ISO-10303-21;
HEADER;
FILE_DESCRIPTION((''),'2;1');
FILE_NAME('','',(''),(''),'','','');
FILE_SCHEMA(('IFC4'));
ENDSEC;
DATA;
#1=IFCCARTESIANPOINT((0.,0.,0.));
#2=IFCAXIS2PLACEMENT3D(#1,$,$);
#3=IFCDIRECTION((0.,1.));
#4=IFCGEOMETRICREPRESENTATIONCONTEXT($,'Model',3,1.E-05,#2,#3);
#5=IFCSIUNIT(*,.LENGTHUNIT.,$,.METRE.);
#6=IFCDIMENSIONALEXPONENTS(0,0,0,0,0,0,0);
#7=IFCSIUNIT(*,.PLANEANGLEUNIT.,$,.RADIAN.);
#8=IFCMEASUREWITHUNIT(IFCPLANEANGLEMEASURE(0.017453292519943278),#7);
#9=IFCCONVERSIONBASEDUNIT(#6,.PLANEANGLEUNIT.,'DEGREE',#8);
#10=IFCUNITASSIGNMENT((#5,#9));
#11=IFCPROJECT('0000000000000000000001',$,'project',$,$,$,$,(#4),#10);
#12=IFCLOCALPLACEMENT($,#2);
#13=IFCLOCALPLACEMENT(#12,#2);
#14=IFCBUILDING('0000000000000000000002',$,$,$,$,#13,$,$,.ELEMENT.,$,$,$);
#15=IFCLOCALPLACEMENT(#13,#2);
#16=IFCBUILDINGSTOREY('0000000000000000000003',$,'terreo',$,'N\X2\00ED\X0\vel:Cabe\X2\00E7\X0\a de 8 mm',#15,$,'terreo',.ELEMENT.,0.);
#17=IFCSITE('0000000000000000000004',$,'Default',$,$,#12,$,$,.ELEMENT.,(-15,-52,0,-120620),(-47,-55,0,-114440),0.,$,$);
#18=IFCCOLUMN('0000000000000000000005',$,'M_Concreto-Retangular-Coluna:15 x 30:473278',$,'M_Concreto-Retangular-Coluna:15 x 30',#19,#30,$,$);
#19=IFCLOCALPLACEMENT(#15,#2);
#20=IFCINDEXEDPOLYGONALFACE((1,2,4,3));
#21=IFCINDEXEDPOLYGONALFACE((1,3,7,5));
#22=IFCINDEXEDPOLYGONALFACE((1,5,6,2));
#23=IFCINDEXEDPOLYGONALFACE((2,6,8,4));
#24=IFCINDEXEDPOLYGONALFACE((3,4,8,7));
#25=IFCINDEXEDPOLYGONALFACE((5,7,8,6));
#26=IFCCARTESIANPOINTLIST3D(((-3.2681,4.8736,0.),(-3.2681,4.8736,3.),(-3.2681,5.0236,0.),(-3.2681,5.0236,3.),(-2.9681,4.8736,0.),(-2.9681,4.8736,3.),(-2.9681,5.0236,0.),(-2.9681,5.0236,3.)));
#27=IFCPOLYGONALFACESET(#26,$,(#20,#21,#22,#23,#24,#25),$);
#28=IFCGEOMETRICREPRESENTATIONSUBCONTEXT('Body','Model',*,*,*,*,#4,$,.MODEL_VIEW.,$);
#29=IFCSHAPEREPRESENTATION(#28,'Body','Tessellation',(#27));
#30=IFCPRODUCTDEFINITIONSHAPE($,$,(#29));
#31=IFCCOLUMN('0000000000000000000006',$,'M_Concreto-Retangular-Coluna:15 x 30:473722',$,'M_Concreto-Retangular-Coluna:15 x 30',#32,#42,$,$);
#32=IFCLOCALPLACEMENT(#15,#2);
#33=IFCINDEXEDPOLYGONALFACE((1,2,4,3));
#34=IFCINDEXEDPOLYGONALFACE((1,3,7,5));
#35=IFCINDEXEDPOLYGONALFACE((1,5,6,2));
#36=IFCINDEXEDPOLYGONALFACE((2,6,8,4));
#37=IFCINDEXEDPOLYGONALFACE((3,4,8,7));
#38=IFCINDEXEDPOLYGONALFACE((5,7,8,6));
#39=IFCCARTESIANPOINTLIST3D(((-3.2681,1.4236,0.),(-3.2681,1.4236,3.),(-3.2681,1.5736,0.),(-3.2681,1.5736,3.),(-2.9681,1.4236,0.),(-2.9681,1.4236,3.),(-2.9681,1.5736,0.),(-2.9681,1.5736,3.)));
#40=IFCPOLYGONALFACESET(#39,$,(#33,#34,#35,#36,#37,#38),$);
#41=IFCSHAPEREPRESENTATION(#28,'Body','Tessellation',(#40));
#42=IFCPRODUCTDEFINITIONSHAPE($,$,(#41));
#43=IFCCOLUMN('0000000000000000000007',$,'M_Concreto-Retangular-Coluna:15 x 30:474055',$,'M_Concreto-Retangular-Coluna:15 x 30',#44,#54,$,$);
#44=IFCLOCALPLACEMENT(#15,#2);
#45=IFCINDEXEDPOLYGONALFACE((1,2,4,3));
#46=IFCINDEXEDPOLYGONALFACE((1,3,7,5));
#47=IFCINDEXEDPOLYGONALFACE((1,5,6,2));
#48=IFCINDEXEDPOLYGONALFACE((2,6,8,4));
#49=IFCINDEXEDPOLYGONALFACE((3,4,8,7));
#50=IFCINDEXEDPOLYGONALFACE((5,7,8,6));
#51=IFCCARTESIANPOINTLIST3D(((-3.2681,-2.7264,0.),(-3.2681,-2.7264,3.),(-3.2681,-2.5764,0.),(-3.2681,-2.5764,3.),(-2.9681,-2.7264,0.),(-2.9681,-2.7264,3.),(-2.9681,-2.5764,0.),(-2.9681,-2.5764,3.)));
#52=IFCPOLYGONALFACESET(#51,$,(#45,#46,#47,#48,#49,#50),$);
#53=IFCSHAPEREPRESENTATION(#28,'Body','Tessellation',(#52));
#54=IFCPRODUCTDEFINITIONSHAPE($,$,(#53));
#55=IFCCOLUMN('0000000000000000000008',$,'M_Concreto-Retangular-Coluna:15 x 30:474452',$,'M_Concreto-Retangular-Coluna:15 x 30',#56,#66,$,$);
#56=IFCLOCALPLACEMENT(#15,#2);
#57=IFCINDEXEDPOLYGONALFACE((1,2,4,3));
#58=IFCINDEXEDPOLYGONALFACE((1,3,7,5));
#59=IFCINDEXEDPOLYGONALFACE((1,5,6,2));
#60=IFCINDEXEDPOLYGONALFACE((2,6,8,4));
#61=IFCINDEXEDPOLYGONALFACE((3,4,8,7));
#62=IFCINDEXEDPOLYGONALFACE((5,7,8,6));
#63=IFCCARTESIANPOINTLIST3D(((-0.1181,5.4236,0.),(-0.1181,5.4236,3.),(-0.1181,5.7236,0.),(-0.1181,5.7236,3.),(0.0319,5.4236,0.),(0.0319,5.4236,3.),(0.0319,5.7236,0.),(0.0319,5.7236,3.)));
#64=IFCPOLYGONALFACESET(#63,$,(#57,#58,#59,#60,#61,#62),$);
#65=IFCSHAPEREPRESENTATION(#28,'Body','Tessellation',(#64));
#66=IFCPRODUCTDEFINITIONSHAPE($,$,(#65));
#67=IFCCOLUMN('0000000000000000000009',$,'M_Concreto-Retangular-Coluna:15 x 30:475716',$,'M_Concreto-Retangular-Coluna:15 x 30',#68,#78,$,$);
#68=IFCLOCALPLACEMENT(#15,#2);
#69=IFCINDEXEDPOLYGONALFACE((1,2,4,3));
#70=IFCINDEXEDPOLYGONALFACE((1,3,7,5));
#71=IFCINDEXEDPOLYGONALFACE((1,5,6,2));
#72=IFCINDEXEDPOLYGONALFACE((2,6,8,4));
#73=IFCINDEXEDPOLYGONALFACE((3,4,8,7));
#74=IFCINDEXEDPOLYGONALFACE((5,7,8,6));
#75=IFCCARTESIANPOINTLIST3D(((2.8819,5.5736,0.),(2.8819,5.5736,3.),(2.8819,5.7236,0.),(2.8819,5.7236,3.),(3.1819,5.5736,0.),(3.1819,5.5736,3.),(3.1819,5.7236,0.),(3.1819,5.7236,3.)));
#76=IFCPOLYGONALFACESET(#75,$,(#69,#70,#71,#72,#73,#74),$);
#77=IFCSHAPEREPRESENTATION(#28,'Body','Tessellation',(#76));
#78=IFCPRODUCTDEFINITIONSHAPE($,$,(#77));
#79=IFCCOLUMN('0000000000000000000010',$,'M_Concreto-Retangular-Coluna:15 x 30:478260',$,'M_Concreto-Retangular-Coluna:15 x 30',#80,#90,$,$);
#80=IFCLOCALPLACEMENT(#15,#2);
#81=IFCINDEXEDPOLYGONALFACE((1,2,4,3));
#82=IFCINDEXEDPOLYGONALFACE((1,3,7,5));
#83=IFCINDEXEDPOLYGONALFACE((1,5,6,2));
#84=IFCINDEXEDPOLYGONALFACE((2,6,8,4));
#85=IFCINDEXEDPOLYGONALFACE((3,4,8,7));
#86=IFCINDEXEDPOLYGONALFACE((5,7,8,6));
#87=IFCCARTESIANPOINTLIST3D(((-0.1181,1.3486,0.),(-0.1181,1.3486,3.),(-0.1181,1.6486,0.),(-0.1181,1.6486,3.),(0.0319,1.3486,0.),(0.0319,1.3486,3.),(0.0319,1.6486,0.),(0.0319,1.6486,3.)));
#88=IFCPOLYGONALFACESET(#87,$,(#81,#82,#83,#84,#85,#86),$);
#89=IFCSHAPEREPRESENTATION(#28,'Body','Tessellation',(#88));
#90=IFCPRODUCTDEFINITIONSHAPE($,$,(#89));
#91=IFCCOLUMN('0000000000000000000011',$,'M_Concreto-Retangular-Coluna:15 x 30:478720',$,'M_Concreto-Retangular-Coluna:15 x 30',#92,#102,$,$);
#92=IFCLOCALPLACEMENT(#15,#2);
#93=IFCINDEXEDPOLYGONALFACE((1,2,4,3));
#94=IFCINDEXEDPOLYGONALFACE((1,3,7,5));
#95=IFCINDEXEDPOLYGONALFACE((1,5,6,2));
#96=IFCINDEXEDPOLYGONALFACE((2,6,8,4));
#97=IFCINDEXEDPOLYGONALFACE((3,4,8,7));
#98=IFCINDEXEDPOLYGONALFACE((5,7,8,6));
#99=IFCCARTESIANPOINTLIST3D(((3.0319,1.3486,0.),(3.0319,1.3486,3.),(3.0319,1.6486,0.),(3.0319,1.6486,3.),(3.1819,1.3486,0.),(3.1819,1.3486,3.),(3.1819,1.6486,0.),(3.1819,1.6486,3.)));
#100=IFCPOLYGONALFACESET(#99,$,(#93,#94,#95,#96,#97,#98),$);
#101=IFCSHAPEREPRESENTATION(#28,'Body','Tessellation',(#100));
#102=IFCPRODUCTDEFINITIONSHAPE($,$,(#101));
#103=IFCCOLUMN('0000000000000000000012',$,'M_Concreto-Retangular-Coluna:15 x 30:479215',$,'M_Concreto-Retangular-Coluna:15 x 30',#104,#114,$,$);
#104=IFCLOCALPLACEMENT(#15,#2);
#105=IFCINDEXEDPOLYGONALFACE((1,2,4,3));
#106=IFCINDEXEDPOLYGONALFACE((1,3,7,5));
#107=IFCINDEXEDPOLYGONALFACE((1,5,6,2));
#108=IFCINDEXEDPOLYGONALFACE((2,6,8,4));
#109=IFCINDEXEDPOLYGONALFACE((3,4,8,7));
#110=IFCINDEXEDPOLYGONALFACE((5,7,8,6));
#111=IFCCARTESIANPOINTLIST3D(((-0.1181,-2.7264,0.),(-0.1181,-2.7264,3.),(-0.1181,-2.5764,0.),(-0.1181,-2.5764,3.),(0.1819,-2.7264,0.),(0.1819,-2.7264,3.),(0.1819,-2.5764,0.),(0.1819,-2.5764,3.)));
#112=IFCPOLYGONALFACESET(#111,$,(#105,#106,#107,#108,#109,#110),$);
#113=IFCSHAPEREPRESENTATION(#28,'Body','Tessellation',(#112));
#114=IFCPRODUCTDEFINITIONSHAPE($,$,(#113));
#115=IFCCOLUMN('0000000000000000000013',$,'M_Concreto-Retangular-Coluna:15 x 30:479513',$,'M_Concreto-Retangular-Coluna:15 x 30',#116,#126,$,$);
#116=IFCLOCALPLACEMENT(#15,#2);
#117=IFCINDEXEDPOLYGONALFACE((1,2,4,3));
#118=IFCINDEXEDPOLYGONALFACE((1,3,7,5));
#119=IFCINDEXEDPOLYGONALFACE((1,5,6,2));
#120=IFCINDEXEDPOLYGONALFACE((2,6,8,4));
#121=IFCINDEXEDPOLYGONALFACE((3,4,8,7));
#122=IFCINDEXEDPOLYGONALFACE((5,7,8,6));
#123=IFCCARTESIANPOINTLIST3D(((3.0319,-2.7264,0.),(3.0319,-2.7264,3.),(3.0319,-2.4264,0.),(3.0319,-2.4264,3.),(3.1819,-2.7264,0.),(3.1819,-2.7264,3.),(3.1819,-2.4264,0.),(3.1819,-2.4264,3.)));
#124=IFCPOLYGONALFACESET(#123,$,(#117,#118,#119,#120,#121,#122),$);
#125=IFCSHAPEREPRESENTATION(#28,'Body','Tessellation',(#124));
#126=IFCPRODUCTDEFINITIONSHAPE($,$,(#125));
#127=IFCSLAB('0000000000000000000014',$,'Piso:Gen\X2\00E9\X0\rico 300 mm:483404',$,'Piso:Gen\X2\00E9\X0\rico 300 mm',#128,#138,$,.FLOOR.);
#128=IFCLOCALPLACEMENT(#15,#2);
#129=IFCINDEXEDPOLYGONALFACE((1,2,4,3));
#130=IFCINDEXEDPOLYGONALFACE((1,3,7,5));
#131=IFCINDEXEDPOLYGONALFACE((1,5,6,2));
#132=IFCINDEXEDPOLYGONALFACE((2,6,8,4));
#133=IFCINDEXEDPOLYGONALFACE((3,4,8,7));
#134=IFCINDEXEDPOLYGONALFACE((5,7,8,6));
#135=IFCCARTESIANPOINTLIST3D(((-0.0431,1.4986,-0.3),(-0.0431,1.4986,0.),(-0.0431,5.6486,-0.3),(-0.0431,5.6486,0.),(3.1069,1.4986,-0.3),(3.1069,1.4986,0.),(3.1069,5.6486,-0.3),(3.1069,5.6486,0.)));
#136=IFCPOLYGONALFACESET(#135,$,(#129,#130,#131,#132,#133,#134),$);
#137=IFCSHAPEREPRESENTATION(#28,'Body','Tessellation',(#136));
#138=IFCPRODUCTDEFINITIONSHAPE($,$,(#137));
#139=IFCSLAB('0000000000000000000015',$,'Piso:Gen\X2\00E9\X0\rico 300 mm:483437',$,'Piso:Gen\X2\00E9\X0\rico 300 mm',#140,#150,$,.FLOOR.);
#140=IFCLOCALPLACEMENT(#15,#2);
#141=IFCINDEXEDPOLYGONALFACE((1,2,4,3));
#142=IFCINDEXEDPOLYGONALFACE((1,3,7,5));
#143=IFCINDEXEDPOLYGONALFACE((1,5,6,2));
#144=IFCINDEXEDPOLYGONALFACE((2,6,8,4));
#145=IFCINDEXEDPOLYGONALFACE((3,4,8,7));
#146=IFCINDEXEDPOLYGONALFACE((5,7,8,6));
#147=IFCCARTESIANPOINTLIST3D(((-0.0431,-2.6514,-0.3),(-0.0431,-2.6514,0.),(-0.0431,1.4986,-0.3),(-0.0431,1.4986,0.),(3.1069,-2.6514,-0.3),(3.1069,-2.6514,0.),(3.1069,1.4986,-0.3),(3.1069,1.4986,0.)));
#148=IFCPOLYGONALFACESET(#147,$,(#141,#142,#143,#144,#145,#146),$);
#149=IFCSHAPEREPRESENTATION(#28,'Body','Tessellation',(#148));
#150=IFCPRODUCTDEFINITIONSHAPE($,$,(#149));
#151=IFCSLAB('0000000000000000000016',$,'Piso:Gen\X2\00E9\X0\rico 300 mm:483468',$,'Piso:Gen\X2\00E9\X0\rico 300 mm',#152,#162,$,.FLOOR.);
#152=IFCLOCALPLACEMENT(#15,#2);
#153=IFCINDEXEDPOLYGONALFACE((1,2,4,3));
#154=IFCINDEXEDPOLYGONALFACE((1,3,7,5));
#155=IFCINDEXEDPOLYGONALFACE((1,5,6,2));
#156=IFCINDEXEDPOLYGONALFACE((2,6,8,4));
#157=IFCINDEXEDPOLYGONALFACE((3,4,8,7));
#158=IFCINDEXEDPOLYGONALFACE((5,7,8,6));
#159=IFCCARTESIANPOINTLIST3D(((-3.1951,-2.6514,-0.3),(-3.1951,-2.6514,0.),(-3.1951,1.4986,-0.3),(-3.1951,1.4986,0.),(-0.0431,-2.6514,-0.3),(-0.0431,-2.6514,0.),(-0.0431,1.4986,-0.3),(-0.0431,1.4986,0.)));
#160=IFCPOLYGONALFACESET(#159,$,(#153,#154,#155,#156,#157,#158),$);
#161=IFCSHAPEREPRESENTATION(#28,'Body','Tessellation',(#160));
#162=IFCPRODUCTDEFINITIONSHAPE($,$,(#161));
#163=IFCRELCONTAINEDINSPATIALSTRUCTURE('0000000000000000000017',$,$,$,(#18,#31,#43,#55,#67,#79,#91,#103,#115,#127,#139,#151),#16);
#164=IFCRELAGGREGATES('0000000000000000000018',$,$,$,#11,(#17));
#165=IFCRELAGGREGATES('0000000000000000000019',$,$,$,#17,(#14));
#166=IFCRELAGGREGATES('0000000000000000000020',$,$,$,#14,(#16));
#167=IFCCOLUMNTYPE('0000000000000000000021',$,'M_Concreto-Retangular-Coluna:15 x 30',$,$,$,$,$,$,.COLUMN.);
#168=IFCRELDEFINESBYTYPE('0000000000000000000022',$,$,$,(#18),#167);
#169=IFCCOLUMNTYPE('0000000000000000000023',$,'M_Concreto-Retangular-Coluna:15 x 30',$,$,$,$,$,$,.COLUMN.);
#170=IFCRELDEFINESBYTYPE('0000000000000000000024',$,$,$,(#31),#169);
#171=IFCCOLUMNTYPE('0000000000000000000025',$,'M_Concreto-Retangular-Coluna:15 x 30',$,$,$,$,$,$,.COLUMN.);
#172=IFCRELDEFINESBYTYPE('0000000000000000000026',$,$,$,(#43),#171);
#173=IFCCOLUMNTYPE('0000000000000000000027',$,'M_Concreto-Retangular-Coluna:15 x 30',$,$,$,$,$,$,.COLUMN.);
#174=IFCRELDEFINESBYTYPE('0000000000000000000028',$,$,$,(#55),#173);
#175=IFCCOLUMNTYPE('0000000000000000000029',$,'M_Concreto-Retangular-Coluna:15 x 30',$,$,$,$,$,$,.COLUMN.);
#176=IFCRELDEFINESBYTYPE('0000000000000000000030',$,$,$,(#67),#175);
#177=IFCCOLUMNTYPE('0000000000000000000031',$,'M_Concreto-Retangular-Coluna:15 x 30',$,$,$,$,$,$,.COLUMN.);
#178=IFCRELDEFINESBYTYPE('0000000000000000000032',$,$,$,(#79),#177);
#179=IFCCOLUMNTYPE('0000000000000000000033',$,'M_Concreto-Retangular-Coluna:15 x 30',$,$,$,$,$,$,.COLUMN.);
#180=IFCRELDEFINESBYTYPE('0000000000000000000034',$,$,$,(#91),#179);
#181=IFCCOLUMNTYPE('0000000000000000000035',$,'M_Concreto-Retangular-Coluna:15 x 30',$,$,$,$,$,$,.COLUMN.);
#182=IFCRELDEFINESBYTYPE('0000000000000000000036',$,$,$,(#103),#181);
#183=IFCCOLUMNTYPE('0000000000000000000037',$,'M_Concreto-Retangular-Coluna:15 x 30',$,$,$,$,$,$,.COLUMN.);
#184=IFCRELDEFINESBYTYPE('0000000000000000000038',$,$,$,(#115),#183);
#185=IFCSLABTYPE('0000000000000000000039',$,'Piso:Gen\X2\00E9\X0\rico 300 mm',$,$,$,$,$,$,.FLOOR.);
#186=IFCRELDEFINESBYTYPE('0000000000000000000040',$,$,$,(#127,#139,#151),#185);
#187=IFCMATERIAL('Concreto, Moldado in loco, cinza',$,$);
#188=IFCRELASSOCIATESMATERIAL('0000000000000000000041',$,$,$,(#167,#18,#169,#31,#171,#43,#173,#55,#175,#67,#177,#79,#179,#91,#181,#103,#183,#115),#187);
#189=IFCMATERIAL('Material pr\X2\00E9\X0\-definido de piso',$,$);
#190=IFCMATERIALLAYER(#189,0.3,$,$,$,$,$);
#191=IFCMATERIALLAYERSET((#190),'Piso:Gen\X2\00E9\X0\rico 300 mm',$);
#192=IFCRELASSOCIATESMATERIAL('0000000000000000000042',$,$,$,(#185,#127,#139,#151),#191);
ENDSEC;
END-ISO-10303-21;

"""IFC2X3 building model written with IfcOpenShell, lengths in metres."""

from ifc_helpers import new_model, entity, si_unit, converted_unit, direction, frame, frame_2d, origin, origin_2d_with_axis, place, context, subcontext, project, spatial, rectangle, extrude, source, transform, mapped, material, layer, layer_set, layer_usage, type_object, type_shapes, element, save


model = new_model("IFC2X3")

# Units and contexts
model_context = context("Model", 3, precision=1e-05, world=origin(), true_north=direction((0.0, 1.0)))
body_context = subcontext(model_context, "Body", "Model", "MODEL_VIEW")
ifc_project = project(units=[si_unit("LENGTHUNIT", "METRE"), converted_unit("PLANEANGLEUNIT", "DEGREE", entity("IfcPlaneAngleMeasure", 0.017453292519943278), si_unit("PLANEANGLEUNIT", "RADIAN"), dimensions=[0, 0, 0, 0, 0, 0, 0])], contexts=[model_context])

# Site, building, storey
site_placement = place(None, origin())
site = spatial("IfcSite", under=ifc_project, at=site_placement, Name="Default", CompositionType="ELEMENT", RefLatitude=(-15, -52, 0, -120620), RefLongitude=(-47, -55, 0, -114440), RefElevation=0.0)
building_placement = place(site_placement, origin())
building = spatial("IfcBuilding", under=site, at=building_placement, CompositionType="ELEMENT")
storey_placement = place(building_placement, origin())
storey = spatial("IfcBuildingStorey", under=building, at=storey_placement, Name="terreo", ObjectType="Nível:Cabeça de 8 mm", LongName="terreo", CompositionType="ELEMENT", Elevation=0.0)

# Columns
ifc_material_1 = material(Name="Concreto, Moldado in loco, cinza")
column_type_1 = type_object("IfcColumnType", Name="M_Concreto-Retangular-Coluna:15 x 30", PredefinedType="COLUMN", material=ifc_material_1)
shared_shape_1 = source(origin(), body_context, "Body", "SweptSolid", [
    extrude(rectangle(XDim=0.15, YDim=0.3, at=frame_2d((0.0, 0.0), x_axis=(1.0, 0.0))), frame((-3.1181, 4.9486, 0.0), z_axis=(0.0, 0.0, 1.0), x_axis=(0.0, -1.0, 0.0)), (0.0, 0.0, 1.0), 3.0),
])
type_shapes(column_type_1, [shared_shape_1])
column_1_placement = place(storey_placement, origin())
element("IfcColumn", 1, at=column_1_placement, inside=storey, type_object=column_type_1, material=ifc_material_1, Name="M_Concreto-Retangular-Coluna:15 x 30:473278", ObjectType="M_Concreto-Retangular-Coluna:15 x 30", context=body_context, shape_type="MappedRepresentation", body=[
    mapped(shared_shape_1, transform((0.0, 0.0, 0.0), scale=1.0)),
])
column_type_2 = type_object("IfcColumnType", Name="M_Concreto-Retangular-Coluna:15 x 30", PredefinedType="COLUMN", material=ifc_material_1)
shared_shape_2 = source(origin(), body_context, "Body", "SweptSolid", [
    extrude(rectangle(XDim=0.15, YDim=0.3, at=origin_2d_with_axis()), frame((-3.1181, 1.4986, 0.0), z_axis=(0.0, 0.0, 1.0), x_axis=(0.0, -1.0, 0.0)), (0.0, 0.0, 1.0), 3.0),
])
type_shapes(column_type_2, [shared_shape_2])
column_2_placement = place(storey_placement, origin())
element("IfcColumn", 2, at=column_2_placement, inside=storey, type_object=column_type_2, material=ifc_material_1, Name="M_Concreto-Retangular-Coluna:15 x 30:473722", ObjectType="M_Concreto-Retangular-Coluna:15 x 30", context=body_context, shape_type="MappedRepresentation", body=[
    mapped(shared_shape_2, transform((0.0, 0.0, 0.0), scale=1.0)),
])
column_type_3 = type_object("IfcColumnType", Name="M_Concreto-Retangular-Coluna:15 x 30", PredefinedType="COLUMN", material=ifc_material_1)
shared_shape_3 = source(origin(), body_context, "Body", "SweptSolid", [
    extrude(rectangle(XDim=0.15, YDim=0.3, at=frame_2d((0.0, 0.0), x_axis=(1.0, 0.0))), frame((-3.1181, -2.6514, 0.0), z_axis=(0.0, 0.0, 1.0), x_axis=(0.0, -1.0, 0.0)), (0.0, 0.0, 1.0), 3.0),
])
type_shapes(column_type_3, [shared_shape_3])
column_3_placement = place(storey_placement, origin())
element("IfcColumn", 3, at=column_3_placement, inside=storey, type_object=column_type_3, material=ifc_material_1, Name="M_Concreto-Retangular-Coluna:15 x 30:474055", ObjectType="M_Concreto-Retangular-Coluna:15 x 30", context=body_context, shape_type="MappedRepresentation", body=[
    mapped(shared_shape_3, transform((0.0, 0.0, 0.0), scale=1.0)),
])
column_type_4 = type_object("IfcColumnType", Name="M_Concreto-Retangular-Coluna:15 x 30", PredefinedType="COLUMN", material=ifc_material_1)
shared_shape_4 = source(origin(), body_context, "Body", "SweptSolid", [
    extrude(rectangle(XDim=0.15, YDim=0.3, at=frame_2d((0.0, 0.0), x_axis=(1.0, 0.0))), frame((-0.0431, 5.5736, 0.0), z_axis=(0.0, 0.0, 1.0), x_axis=(-1.0, 0.0, 0.0)), (0.0, 0.0, 1.0), 3.0),
])
type_shapes(column_type_4, [shared_shape_4])
column_4_placement = place(storey_placement, origin())
element("IfcColumn", 4, at=column_4_placement, inside=storey, type_object=column_type_4, material=ifc_material_1, Name="M_Concreto-Retangular-Coluna:15 x 30:474452", ObjectType="M_Concreto-Retangular-Coluna:15 x 30", context=body_context, shape_type="MappedRepresentation", body=[
    mapped(shared_shape_4, transform((0.0, 0.0, 0.0), scale=1.0)),
])
column_type_5 = type_object("IfcColumnType", Name="M_Concreto-Retangular-Coluna:15 x 30", PredefinedType="COLUMN", material=ifc_material_1)
shared_shape_5 = source(origin(), body_context, "Body", "SweptSolid", [
    extrude(rectangle(XDim=0.15, YDim=0.3, at=frame_2d((0.0, 0.0), x_axis=(1.0, 0.0))), frame((3.0319, 5.6486, 0.0), z_axis=(0.0, 0.0, 1.0), x_axis=(0.0, -1.0, 0.0)), (0.0, 0.0, 1.0), 3.0),
])
type_shapes(column_type_5, [shared_shape_5])
column_5_placement = place(storey_placement, origin())
element("IfcColumn", 5, at=column_5_placement, inside=storey, type_object=column_type_5, material=ifc_material_1, Name="M_Concreto-Retangular-Coluna:15 x 30:475716", ObjectType="M_Concreto-Retangular-Coluna:15 x 30", context=body_context, shape_type="MappedRepresentation", body=[
    mapped(shared_shape_5, transform((0.0, 0.0, 0.0), scale=1.0)),
])
column_type_6 = type_object("IfcColumnType", Name="M_Concreto-Retangular-Coluna:15 x 30", PredefinedType="COLUMN", material=ifc_material_1)
shared_shape_6 = source(origin(), body_context, "Body", "SweptSolid", [
    extrude(rectangle(XDim=0.15, YDim=0.3, at=origin_2d_with_axis()), frame((-0.0431, 1.4986, 0.0), z_axis=(0.0, 0.0, 1.0), x_axis=(-1.0, 0.0, 0.0)), (0.0, 0.0, 1.0), 3.0),
])
type_shapes(column_type_6, [shared_shape_6])
column_6_placement = place(storey_placement, origin())
element("IfcColumn", 6, at=column_6_placement, inside=storey, type_object=column_type_6, material=ifc_material_1, Name="M_Concreto-Retangular-Coluna:15 x 30:478260", ObjectType="M_Concreto-Retangular-Coluna:15 x 30", context=body_context, shape_type="MappedRepresentation", body=[
    mapped(shared_shape_6, transform((0.0, 0.0, 0.0), scale=1.0)),
])
column_type_7 = type_object("IfcColumnType", Name="M_Concreto-Retangular-Coluna:15 x 30", PredefinedType="COLUMN", material=ifc_material_1)
shared_shape_7 = source(origin(), body_context, "Body", "SweptSolid", [
    extrude(rectangle(XDim=0.15, YDim=0.3, at=frame_2d((0.0, 0.0), x_axis=(1.0, 0.0))), frame((3.1069, 1.4986, 0.0), z_axis=(0.0, 0.0, 1.0), x_axis=(-1.0, 0.0, 0.0)), (0.0, 0.0, 1.0), 3.0),
])
type_shapes(column_type_7, [shared_shape_7])
column_7_placement = place(storey_placement, origin())
element("IfcColumn", 7, at=column_7_placement, inside=storey, type_object=column_type_7, material=ifc_material_1, Name="M_Concreto-Retangular-Coluna:15 x 30:478720", ObjectType="M_Concreto-Retangular-Coluna:15 x 30", context=body_context, shape_type="MappedRepresentation", body=[
    mapped(shared_shape_7, transform((0.0, 0.0, 0.0), scale=1.0)),
])
column_type_8 = type_object("IfcColumnType", Name="M_Concreto-Retangular-Coluna:15 x 30", PredefinedType="COLUMN", material=ifc_material_1)
shared_shape_8 = source(origin(), body_context, "Body", "SweptSolid", [
    extrude(rectangle(XDim=0.15, YDim=0.3, at=frame_2d((0.0, 0.0), x_axis=(1.0, 0.0))), frame((0.0319, -2.6514, 0.0), z_axis=(0.0, 0.0, 1.0), x_axis=(0.0, -1.0, 0.0)), (0.0, 0.0, 1.0), 3.0),
])
type_shapes(column_type_8, [shared_shape_8])
column_8_placement = place(storey_placement, origin())
element("IfcColumn", 8, at=column_8_placement, inside=storey, type_object=column_type_8, material=ifc_material_1, Name="M_Concreto-Retangular-Coluna:15 x 30:479215", ObjectType="M_Concreto-Retangular-Coluna:15 x 30", context=body_context, shape_type="MappedRepresentation", body=[
    mapped(shared_shape_8, transform((0.0, 0.0, 0.0), scale=1.0)),
])
column_type_9 = type_object("IfcColumnType", Name="M_Concreto-Retangular-Coluna:15 x 30", PredefinedType="COLUMN", material=ifc_material_1)
shared_shape_9 = source(origin(), body_context, "Body", "SweptSolid", [
    extrude(rectangle(XDim=0.15, YDim=0.3, at=frame_2d((0.0, 0.0), x_axis=(1.0, 0.0))), frame((3.1069, -2.5764, 0.0), z_axis=(0.0, 0.0, 1.0), x_axis=(-1.0, 0.0, 0.0)), (0.0, 0.0, 1.0), 3.0),
])
type_shapes(column_type_9, [shared_shape_9])
column_9_placement = place(storey_placement, origin())
element("IfcColumn", 9, at=column_9_placement, inside=storey, type_object=column_type_9, material=ifc_material_1, Name="M_Concreto-Retangular-Coluna:15 x 30:479513", ObjectType="M_Concreto-Retangular-Coluna:15 x 30", context=body_context, shape_type="MappedRepresentation", body=[
    mapped(shared_shape_9, transform((0.0, 0.0, 0.0), scale=1.0)),
])

# Slabs
ifc_material_2 = material(Name="Material pré-definido de piso")
ifc_layer = layer(ifc_material_2, 0.3)
ifc_layer_set = layer_set([ifc_layer], Name="Piso:Genérico 300 mm")
ifc_layer_usage_1 = layer_usage(ifc_layer_set, "AXIS3", "POSITIVE", 0.0)
slab_type = type_object("IfcSlabType", Name="Piso:Genérico 300 mm", PredefinedType="FLOOR", material=ifc_layer_set)
slab_1_placement = place(storey_placement, origin())
element("IfcSlab", 10, at=slab_1_placement, inside=storey, type_object=slab_type, material=ifc_layer_usage_1, Name="Piso:Genérico 300 mm:483404", ObjectType="Piso:Genérico 300 mm", PredefinedType="FLOOR", context=body_context, shape_type="SweptSolid", body=[
    extrude(rectangle(XDim=4.15, YDim=3.15, at=origin_2d_with_axis()), frame((1.5319, 3.5736, 0.0), z_axis=(0.0, 0.0, -1.0), x_axis=(0.0, 1.0, 0.0)), (0.0, 0.0, 1.0), 0.3),
])
ifc_layer_usage_2 = layer_usage(ifc_layer_set, "AXIS3", "POSITIVE", 0.0)
slab_2_placement = place(storey_placement, origin())
element("IfcSlab", 11, at=slab_2_placement, inside=storey, type_object=slab_type, material=ifc_layer_usage_2, Name="Piso:Genérico 300 mm:483437", ObjectType="Piso:Genérico 300 mm", PredefinedType="FLOOR", context=body_context, shape_type="SweptSolid", body=[
    extrude(rectangle(XDim=4.15, YDim=3.15, at=origin_2d_with_axis()), frame((1.5319, -0.5764, 0.0), z_axis=(0.0, 0.0, -1.0), x_axis=(0.0, 1.0, 0.0)), (0.0, 0.0, 1.0), 0.3),
])
ifc_layer_usage_3 = layer_usage(ifc_layer_set, "AXIS3", "POSITIVE", 0.0)
slab_3_placement = place(storey_placement, origin())
element("IfcSlab", 12, at=slab_3_placement, inside=storey, type_object=slab_type, material=ifc_layer_usage_3, Name="Piso:Genérico 300 mm:483468", ObjectType="Piso:Genérico 300 mm", PredefinedType="FLOOR", context=body_context, shape_type="SweptSolid", body=[
    extrude(rectangle(XDim=4.15, YDim=3.152, at=origin_2d_with_axis()), frame((-1.6191, -0.5764, 0.0), z_axis=(0.0, 0.0, -1.0), x_axis=(0.0, 1.0, 0.0)), (0.0, 0.0, 1.0), 0.3),
])

save(model, "model.ifc")
